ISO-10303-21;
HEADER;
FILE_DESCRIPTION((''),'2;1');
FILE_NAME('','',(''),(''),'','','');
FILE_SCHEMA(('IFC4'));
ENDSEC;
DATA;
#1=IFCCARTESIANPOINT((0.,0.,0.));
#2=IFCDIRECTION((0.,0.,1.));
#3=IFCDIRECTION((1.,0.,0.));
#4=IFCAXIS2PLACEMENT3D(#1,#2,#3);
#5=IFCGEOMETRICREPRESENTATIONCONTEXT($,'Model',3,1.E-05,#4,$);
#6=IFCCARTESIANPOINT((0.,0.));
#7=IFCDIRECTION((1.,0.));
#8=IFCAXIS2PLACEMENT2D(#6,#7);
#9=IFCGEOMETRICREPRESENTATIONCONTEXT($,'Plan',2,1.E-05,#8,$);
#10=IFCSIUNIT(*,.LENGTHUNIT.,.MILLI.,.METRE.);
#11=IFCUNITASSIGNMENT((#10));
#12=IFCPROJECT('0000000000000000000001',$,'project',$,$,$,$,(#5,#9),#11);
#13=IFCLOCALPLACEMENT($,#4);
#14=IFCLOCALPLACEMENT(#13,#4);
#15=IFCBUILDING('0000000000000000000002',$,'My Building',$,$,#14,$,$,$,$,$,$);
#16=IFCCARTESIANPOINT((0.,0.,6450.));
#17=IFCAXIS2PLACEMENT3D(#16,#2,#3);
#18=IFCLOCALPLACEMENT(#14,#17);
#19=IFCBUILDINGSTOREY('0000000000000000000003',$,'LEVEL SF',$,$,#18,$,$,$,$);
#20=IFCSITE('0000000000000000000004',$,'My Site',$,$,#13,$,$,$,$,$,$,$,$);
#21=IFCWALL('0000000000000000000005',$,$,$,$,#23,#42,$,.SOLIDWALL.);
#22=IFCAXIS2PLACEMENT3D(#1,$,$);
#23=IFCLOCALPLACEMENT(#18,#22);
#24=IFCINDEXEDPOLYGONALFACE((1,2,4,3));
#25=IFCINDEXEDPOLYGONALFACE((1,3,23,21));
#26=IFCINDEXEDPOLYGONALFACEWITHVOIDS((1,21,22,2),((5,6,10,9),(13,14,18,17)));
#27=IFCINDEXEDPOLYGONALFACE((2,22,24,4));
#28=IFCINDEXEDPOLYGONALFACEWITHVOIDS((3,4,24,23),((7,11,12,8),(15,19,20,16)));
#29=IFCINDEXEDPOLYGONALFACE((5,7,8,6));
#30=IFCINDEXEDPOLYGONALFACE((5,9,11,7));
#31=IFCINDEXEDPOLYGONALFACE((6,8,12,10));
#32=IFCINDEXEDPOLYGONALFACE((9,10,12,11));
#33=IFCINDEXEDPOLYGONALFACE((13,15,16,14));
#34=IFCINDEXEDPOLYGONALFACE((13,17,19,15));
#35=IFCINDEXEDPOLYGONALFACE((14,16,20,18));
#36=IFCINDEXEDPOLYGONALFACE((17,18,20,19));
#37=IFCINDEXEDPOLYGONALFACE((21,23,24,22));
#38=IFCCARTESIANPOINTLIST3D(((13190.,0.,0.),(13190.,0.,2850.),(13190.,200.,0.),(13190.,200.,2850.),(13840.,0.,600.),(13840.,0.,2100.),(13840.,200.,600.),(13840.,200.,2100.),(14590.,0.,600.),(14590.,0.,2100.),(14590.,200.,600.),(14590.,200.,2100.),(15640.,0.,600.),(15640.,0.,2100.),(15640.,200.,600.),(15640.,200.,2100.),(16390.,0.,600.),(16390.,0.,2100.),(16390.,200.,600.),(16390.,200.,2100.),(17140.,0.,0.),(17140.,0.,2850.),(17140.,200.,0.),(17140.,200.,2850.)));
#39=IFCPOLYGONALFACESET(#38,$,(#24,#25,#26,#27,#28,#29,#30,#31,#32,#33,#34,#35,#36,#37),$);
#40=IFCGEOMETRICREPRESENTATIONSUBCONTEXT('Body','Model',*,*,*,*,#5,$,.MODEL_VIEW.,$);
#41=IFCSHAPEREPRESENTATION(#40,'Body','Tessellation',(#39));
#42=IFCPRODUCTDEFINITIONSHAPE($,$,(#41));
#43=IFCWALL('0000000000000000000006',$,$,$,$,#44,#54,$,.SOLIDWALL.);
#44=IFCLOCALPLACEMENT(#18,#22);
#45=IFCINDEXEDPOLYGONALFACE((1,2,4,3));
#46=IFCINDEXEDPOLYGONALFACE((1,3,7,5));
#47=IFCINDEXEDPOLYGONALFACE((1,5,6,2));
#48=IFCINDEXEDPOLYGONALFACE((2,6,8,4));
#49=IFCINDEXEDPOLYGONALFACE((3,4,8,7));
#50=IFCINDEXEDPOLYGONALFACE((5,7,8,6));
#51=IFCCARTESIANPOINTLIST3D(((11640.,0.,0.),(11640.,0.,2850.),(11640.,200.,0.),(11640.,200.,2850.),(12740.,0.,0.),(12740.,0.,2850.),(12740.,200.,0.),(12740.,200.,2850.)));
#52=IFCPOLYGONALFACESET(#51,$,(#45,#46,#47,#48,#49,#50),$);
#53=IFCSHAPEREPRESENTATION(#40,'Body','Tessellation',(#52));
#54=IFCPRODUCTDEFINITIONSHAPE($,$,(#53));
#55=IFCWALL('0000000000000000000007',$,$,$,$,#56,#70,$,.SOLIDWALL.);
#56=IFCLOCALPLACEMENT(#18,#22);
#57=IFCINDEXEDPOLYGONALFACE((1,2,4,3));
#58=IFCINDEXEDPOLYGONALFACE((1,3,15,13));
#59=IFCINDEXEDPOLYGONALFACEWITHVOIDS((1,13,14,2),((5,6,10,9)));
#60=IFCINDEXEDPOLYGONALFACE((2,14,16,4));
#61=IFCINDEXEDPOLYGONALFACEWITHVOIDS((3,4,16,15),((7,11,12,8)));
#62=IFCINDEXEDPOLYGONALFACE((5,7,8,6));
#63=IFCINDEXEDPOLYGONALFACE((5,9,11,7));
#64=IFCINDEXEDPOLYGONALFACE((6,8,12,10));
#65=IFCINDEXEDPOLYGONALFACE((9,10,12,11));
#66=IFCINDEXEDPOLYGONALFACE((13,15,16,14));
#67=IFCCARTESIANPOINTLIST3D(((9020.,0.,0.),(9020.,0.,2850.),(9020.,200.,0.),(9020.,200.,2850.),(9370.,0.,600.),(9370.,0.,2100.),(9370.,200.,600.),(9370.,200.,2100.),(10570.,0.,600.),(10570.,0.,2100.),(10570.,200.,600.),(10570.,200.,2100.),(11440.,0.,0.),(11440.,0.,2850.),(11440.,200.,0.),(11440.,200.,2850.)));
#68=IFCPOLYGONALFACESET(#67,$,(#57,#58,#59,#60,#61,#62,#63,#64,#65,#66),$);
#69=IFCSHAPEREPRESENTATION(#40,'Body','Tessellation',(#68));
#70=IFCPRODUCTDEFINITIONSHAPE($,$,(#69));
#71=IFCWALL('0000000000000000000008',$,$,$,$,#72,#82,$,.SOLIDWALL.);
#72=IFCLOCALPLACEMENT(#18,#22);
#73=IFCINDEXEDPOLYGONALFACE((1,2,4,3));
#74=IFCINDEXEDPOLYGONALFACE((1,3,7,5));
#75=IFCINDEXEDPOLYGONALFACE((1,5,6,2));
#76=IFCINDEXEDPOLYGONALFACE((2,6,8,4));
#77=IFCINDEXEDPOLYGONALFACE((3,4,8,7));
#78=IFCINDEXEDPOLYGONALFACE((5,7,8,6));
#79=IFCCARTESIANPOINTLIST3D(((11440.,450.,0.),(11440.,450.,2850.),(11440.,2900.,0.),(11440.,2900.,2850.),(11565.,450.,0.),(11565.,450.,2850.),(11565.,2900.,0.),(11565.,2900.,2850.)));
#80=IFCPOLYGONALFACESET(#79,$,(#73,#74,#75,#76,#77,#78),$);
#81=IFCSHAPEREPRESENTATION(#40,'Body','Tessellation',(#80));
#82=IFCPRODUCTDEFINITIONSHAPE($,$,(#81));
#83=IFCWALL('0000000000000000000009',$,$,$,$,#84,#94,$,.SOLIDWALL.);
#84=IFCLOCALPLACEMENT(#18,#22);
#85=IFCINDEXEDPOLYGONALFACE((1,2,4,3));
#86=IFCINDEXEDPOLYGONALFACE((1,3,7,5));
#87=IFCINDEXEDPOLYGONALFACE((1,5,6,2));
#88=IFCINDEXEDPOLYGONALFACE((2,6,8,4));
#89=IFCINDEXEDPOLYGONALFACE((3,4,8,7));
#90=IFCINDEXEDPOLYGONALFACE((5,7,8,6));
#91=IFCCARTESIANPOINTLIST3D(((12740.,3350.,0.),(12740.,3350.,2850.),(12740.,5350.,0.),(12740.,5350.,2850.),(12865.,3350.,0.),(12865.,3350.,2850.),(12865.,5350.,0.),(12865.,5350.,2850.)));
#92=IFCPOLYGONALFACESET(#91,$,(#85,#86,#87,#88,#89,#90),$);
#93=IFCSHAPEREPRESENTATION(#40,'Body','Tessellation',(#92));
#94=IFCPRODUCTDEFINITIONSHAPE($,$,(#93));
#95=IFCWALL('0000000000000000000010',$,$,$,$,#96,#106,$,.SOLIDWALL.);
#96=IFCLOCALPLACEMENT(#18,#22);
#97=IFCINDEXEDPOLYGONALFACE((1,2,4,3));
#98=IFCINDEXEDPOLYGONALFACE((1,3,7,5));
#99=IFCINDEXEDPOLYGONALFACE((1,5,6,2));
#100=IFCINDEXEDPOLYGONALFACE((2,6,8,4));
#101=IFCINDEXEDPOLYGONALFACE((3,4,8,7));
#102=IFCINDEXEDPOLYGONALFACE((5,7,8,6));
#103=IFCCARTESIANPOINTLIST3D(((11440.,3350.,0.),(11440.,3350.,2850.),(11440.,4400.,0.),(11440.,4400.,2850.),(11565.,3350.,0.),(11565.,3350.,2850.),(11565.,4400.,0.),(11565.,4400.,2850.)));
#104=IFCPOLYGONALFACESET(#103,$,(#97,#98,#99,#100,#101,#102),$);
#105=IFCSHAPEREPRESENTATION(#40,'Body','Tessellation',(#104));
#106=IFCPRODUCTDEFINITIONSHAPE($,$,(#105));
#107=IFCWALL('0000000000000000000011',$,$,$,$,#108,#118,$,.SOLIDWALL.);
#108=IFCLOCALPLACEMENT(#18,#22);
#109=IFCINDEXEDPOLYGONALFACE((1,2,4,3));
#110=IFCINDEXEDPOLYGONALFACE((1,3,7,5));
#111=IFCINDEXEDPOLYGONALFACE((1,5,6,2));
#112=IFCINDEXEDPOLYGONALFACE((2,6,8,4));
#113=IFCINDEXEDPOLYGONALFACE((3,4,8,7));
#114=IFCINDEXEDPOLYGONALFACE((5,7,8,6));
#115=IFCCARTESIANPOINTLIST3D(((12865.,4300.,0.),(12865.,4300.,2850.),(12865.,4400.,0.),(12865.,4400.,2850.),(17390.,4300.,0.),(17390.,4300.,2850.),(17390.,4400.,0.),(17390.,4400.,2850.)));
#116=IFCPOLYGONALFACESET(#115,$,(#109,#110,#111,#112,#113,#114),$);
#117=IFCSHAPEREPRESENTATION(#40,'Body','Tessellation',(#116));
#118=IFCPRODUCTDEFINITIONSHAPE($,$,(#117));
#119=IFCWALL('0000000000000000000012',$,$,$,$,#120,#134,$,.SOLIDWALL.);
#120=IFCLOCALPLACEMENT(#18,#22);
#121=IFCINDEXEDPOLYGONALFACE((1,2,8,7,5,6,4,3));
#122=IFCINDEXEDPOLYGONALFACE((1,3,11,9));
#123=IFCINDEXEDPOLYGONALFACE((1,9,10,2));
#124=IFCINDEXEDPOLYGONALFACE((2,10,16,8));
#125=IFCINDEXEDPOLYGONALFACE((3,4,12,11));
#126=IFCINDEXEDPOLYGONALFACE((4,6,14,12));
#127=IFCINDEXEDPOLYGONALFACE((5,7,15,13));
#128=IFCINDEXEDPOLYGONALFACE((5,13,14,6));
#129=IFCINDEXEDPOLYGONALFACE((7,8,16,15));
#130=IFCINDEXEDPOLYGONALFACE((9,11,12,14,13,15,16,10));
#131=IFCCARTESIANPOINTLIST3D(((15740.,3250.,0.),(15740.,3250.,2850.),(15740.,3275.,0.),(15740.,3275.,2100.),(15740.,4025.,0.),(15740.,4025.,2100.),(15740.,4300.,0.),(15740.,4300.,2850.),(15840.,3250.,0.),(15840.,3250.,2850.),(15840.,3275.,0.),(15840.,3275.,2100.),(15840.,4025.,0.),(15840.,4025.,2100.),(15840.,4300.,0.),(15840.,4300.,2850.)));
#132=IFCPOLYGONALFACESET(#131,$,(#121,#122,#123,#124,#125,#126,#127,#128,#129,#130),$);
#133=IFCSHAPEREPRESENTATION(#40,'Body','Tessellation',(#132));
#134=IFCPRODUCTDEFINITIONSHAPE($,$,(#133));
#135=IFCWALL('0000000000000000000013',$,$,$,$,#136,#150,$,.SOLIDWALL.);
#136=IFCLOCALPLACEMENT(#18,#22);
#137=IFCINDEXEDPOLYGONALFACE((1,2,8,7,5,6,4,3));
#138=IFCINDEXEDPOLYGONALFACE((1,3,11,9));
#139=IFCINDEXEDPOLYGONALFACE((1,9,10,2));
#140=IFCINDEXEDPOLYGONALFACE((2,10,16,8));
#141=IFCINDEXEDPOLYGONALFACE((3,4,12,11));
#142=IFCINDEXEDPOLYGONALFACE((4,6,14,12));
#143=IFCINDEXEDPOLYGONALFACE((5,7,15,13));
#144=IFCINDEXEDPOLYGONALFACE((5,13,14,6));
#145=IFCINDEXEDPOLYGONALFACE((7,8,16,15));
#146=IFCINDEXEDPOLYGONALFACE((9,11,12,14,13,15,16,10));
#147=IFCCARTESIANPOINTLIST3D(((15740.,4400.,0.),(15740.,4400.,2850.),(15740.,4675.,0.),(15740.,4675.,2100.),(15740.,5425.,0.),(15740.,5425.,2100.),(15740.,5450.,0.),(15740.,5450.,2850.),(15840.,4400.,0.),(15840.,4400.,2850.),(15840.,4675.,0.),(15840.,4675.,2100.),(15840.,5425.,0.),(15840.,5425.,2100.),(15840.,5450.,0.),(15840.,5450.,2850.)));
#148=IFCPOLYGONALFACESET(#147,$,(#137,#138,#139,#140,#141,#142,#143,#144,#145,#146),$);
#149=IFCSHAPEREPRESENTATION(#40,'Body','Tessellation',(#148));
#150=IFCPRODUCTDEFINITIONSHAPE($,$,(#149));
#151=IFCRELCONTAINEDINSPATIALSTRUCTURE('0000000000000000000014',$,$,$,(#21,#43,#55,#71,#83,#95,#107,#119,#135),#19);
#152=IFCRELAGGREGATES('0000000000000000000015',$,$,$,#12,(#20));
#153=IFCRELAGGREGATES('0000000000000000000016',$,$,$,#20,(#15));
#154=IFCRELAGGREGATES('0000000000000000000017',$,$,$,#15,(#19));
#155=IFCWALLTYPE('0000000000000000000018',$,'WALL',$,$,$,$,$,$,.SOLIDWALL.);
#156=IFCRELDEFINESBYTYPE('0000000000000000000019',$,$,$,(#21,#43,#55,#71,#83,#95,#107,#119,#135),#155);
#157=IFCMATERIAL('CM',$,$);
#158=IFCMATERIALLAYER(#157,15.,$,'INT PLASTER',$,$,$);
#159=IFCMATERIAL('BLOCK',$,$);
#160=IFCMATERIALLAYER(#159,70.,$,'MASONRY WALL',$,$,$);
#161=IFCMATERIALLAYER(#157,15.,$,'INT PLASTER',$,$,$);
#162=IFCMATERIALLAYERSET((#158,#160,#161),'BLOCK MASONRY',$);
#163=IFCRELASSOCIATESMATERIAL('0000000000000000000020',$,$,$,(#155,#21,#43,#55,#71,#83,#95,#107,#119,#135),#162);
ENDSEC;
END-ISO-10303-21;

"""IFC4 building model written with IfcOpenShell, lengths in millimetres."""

from ifc_helpers import new_model, si_unit, frame, origin_with_axes, origin_2d_with_axis, place, context, subcontext, project, spatial, indexed_curve, outline, extrude, material, layer, layer_set, layer_usage, type_object, element, save


model = new_model("IFC4")

# Units and contexts
model_context = context("Model", 3, precision=1e-05, world=origin_with_axes())
plan_context = context("Plan", 2, precision=1e-05, world=origin_2d_with_axis())
body_context = subcontext(model_context, "Body", "Model", "MODEL_VIEW")
ifc_project = project(units=[si_unit("LENGTHUNIT", "METRE", prefix="MILLI")], contexts=[model_context, plan_context])

# Site, building, storey
site_placement = place(None, origin_with_axes())
site = spatial("IfcSite", under=ifc_project, at=site_placement, Name="My Site")
building_placement = place(site_placement, origin_with_axes())
building = spatial("IfcBuilding", under=site, at=building_placement, Name="My Building")
storey_placement = place(building_placement, frame((0.0, 0.0, 6450.0), z_axis=(0.0, 0.0, 1.0), x_axis=(1.0, 0.0, 0.0)))
storey = spatial("IfcBuildingStorey", under=building, at=storey_placement, Name="LEVEL SF")

# Shared definitions
ifc_material_1 = material(Name="CM")
ifc_layer_1 = layer(ifc_material_1, 15.0, Name="INT PLASTER")
ifc_material_2 = material(Name="BLOCK")
ifc_layer_2 = layer(ifc_material_2, 70.0, Name="MASONRY WALL")
ifc_layer_3 = layer(ifc_material_1, 15.0, Name="INT PLASTER")
ifc_layer_set = layer_set([ifc_layer_1, ifc_layer_2, ifc_layer_3], Name="BLOCK MASONRY")
wall_type = type_object("IfcWallType", Name="WALL", PredefinedType="SOLIDWALL", material=ifc_layer_set)

# Wall, openings
ifc_layer_usage_1 = layer_usage(ifc_layer_set, "AXIS2", "POSITIVE", 0.0)
wall_1_placement = place(storey_placement, frame((13190.0, 200.0, 0.0), z_axis=(0.0, 0.0, 1.0), x_axis=(0.0, -1.0, 0.0)))
wall_1 = element("IfcWall", 1, at=wall_1_placement, inside=storey, type_object=wall_type, material=ifc_layer_usage_1, PredefinedType="SOLIDWALL", context=body_context, shape_type="SweptSolid", body=[
    extrude(outline(indexed_curve([(0.0, 0.0), (0.0, 3950.0), (200.0, 3950.0), (200.0, 0.0), (0.0, 0.0)], self_intersect=False)), origin_with_axes(), (0.0, 0.0, 1.0), 2850.0),
])
opening_1_placement = place(wall_1_placement, frame((0.0, 1400.0, 600.0), z_axis=(0.0, 0.0, 1.0), x_axis=(0.0, -1.0, 0.0)))
element("IfcOpeningElement", 2, at=opening_1_placement, cuts=wall_1, PredefinedType="OPENING", context=body_context, shape_type="SweptSolid", body=[
    extrude(outline(indexed_curve([(0.0, 0.0), (0.0, 400.0), (750.0, 400.0), (750.0, 0.0), (0.0, 0.0)], self_intersect=False)), frame((0.0, -100.0, 0.0), z_axis=(0.0, 0.0, 1.0), x_axis=(1.0, 0.0, 0.0)), (0.0, 0.0, 1.0), 1500.0),
])
opening_2_placement = place(wall_1_placement, frame((0.0, 3200.0, 600.0), z_axis=(0.0, 0.0, 1.0), x_axis=(0.0, -1.0, 0.0)))
element("IfcOpeningElement", 3, at=opening_2_placement, cuts=wall_1, PredefinedType="OPENING", context=body_context, shape_type="SweptSolid", body=[
    extrude(outline(indexed_curve([(0.0, 0.0), (0.0, 400.0), (750.0, 400.0), (750.0, 0.0), (0.0, 0.0)], self_intersect=False)), frame((0.0, -100.0, 0.0), z_axis=(0.0, 0.0, 1.0), x_axis=(1.0, 0.0, 0.0)), (0.0, 0.0, 1.0), 1500.0),
])

# Wall
ifc_layer_usage_2 = layer_usage(ifc_layer_set, "AXIS2", "POSITIVE", 0.0)
wall_2_placement = place(storey_placement, frame((11640.0, 200.0, 0.0), z_axis=(0.0, 0.0, 1.0), x_axis=(0.0, -1.0, 0.0)))
element("IfcWall", 4, at=wall_2_placement, inside=storey, type_object=wall_type, material=ifc_layer_usage_2, PredefinedType="SOLIDWALL", context=body_context, shape_type="SweptSolid", body=[
    extrude(outline(indexed_curve([(0.0, 0.0), (0.0, 1100.0), (200.0, 1100.0), (200.0, 0.0), (0.0, 0.0)], self_intersect=False)), origin_with_axes(), (0.0, 0.0, 1.0), 2850.0),
])

# Wall, opening
ifc_layer_usage_3 = layer_usage(ifc_layer_set, "AXIS2", "POSITIVE", 0.0)
wall_3_placement = place(storey_placement, frame((9020.0, 200.0, 0.0), z_axis=(0.0, 0.0, 1.0), x_axis=(0.0, -1.0, 0.0)))
wall_3 = element("IfcWall", 5, at=wall_3_placement, inside=storey, type_object=wall_type, material=ifc_layer_usage_3, PredefinedType="SOLIDWALL", context=body_context, shape_type="SweptSolid", body=[
    extrude(outline(indexed_curve([(0.0, 0.0), (0.0, 2420.0), (200.0, 2420.0), (200.0, 0.0), (0.0, 0.0)], self_intersect=False)), origin_with_axes(), (0.0, 0.0, 1.0), 2850.0),
])
opening_3_placement = place(wall_3_placement, frame((0.0, 1550.0, 600.0), z_axis=(0.0, 0.0, 1.0), x_axis=(0.0, -1.0, 0.0)))
element("IfcOpeningElement", 6, at=opening_3_placement, cuts=wall_3, PredefinedType="OPENING", context=body_context, shape_type="SweptSolid", body=[
    extrude(outline(indexed_curve([(0.0, 0.0), (0.0, 400.0), (1200.0, 400.0), (1200.0, 0.0), (0.0, 0.0)], self_intersect=False)), frame((0.0, -100.0, 0.0), z_axis=(0.0, 0.0, 1.0), x_axis=(1.0, 0.0, 0.0)), (0.0, 0.0, 1.0), 1500.0),
])

# Wall
ifc_layer_usage_4 = layer_usage(ifc_layer_set, "AXIS2", "POSITIVE", 0.0)
wall_4_placement = place(storey_placement, frame((11565.0, 450.0, 0.0), z_axis=(0.0, 0.0, 1.0), x_axis=(0.0, 1.0, 0.0)))
element("IfcWall", 7, at=wall_4_placement, inside=storey, type_object=wall_type, material=ifc_layer_usage_4, PredefinedType="SOLIDWALL", context=body_context, shape_type="SweptSolid", body=[
    extrude(outline(indexed_curve([(0.0, 0.0), (0.0, 125.0), (2450.0, 125.0), (2450.0, 0.0), (0.0, 0.0)], self_intersect=False)), origin_with_axes(), (0.0, 0.0, 1.0), 2850.0),
])

# Walls
ifc_layer_usage_5 = layer_usage(ifc_layer_set, "AXIS2", "POSITIVE", 0.0)
wall_5_placement = place(storey_placement, frame((12865.0, 3350.0, 0.0), z_axis=(0.0, 0.0, 1.0), x_axis=(0.0, 1.0, 0.0)))
element("IfcWall", 8, at=wall_5_placement, inside=storey, type_object=wall_type, material=ifc_layer_usage_5, PredefinedType="SOLIDWALL", context=body_context, shape_type="SweptSolid", body=[
    extrude(outline(indexed_curve([(0.0, 0.0), (0.0, 125.0), (2000.0, 125.0), (2000.0, 0.0), (0.0, 0.0)], self_intersect=False)), origin_with_axes(), (0.0, 0.0, 1.0), 2850.0),
])
ifc_layer_usage_6 = layer_usage(ifc_layer_set, "AXIS2", "POSITIVE", 0.0)
wall_6_placement = place(storey_placement, frame((11565.0, 3350.0, 0.0), z_axis=(0.0, 0.0, 1.0), x_axis=(0.0, 1.0, 0.0)))
element("IfcWall", 9, at=wall_6_placement, inside=storey, type_object=wall_type, material=ifc_layer_usage_6, PredefinedType="SOLIDWALL", context=body_context, shape_type="SweptSolid", body=[
    extrude(outline(indexed_curve([(0.0, 0.0), (0.0, 125.0), (1050.0, 125.0), (1050.0, 0.0), (0.0, 0.0)], self_intersect=False)), origin_with_axes(), (0.0, 0.0, 1.0), 2850.0),
])
ifc_layer_usage_7 = layer_usage(ifc_layer_set, "AXIS2", "POSITIVE", 0.0)
wall_7_placement = place(storey_placement, frame((12865.0, 4400.0, 0.0), z_axis=(0.0, 0.0, 1.0), x_axis=(0.0, -1.0, 0.0)))
element("IfcWall", 10, at=wall_7_placement, inside=storey, type_object=wall_type, material=ifc_layer_usage_7, PredefinedType="SOLIDWALL", context=body_context, shape_type="SweptSolid", body=[
    extrude(outline(indexed_curve([(0.0, 0.0), (0.0, 4525.0), (100.0, 4525.0), (100.0, 0.0), (0.0, 0.0)], self_intersect=False)), origin_with_axes(), (0.0, 0.0, 1.0), 2850.0),
])

# Walls, openings
ifc_layer_usage_8 = layer_usage(ifc_layer_set, "AXIS2", "POSITIVE", 0.0)
wall_8_placement = place(storey_placement, frame((15840.0, 3250.0, 0.0), z_axis=(0.0, 0.0, 1.0), x_axis=(0.0, 1.0, 0.0)))
wall_8 = element("IfcWall", 11, at=wall_8_placement, inside=storey, type_object=wall_type, material=ifc_layer_usage_8, PredefinedType="SOLIDWALL", context=body_context, shape_type="SweptSolid", body=[
    extrude(outline(indexed_curve([(0.0, 0.0), (0.0, 100.0), (1050.0, 100.0), (1050.0, 0.0), (0.0, 0.0)], self_intersect=False)), origin_with_axes(), (0.0, 0.0, 1.0), 2850.0),
])
opening_4_placement = place(wall_8_placement, frame((775.0, 100.0, 0.0), z_axis=(0.0, 0.0, 1.0), x_axis=(-1.0, 0.0, 0.0)))
element("IfcOpeningElement", 12, at=opening_4_placement, cuts=wall_8, PredefinedType="OPENING", context=body_context, shape_type="SweptSolid", body=[
    extrude(outline(indexed_curve([(0.0, 0.0), (0.0, 400.0), (750.0, 400.0), (750.0, 0.0), (0.0, 0.0)], self_intersect=False)), frame((0.0, -100.0, 0.0), z_axis=(0.0, 0.0, 1.0), x_axis=(1.0, 0.0, 0.0)), (0.0, 0.0, 1.0), 2100.0),
])
ifc_layer_usage_9 = layer_usage(ifc_layer_set, "AXIS2", "POSITIVE", 0.0)
wall_9_placement = place(storey_placement, frame((15840.0, 4400.0, 0.0), z_axis=(0.0, 0.0, 1.0), x_axis=(0.0, 1.0, 0.0)))
wall_9 = element("IfcWall", 13, at=wall_9_placement, inside=storey, type_object=wall_type, material=ifc_layer_usage_9, PredefinedType="SOLIDWALL", context=body_context, shape_type="SweptSolid", body=[
    extrude(outline(indexed_curve([(0.0, 0.0), (0.0, 100.0), (1050.0, 100.0), (1050.0, 0.0), (0.0, 0.0)], self_intersect=False)), origin_with_axes(), (0.0, 0.0, 1.0), 2850.0),
])
opening_5_placement = place(wall_9_placement, frame((1025.0, 100.0, 0.0), z_axis=(0.0, 0.0, 1.0), x_axis=(-1.0, 0.0, 0.0)))
element("IfcOpeningElement", 14, at=opening_5_placement, cuts=wall_9, PredefinedType="OPENING", context=body_context, shape_type="SweptSolid", body=[
    extrude(outline(indexed_curve([(0.0, 0.0), (0.0, 400.0), (750.0, 400.0), (750.0, 0.0), (0.0, 0.0)], self_intersect=False)), frame((0.0, -100.0, 0.0), z_axis=(0.0, 0.0, 1.0), x_axis=(1.0, 0.0, 0.0)), (0.0, 0.0, 1.0), 2100.0),
])

save(model, "model.ifc")
